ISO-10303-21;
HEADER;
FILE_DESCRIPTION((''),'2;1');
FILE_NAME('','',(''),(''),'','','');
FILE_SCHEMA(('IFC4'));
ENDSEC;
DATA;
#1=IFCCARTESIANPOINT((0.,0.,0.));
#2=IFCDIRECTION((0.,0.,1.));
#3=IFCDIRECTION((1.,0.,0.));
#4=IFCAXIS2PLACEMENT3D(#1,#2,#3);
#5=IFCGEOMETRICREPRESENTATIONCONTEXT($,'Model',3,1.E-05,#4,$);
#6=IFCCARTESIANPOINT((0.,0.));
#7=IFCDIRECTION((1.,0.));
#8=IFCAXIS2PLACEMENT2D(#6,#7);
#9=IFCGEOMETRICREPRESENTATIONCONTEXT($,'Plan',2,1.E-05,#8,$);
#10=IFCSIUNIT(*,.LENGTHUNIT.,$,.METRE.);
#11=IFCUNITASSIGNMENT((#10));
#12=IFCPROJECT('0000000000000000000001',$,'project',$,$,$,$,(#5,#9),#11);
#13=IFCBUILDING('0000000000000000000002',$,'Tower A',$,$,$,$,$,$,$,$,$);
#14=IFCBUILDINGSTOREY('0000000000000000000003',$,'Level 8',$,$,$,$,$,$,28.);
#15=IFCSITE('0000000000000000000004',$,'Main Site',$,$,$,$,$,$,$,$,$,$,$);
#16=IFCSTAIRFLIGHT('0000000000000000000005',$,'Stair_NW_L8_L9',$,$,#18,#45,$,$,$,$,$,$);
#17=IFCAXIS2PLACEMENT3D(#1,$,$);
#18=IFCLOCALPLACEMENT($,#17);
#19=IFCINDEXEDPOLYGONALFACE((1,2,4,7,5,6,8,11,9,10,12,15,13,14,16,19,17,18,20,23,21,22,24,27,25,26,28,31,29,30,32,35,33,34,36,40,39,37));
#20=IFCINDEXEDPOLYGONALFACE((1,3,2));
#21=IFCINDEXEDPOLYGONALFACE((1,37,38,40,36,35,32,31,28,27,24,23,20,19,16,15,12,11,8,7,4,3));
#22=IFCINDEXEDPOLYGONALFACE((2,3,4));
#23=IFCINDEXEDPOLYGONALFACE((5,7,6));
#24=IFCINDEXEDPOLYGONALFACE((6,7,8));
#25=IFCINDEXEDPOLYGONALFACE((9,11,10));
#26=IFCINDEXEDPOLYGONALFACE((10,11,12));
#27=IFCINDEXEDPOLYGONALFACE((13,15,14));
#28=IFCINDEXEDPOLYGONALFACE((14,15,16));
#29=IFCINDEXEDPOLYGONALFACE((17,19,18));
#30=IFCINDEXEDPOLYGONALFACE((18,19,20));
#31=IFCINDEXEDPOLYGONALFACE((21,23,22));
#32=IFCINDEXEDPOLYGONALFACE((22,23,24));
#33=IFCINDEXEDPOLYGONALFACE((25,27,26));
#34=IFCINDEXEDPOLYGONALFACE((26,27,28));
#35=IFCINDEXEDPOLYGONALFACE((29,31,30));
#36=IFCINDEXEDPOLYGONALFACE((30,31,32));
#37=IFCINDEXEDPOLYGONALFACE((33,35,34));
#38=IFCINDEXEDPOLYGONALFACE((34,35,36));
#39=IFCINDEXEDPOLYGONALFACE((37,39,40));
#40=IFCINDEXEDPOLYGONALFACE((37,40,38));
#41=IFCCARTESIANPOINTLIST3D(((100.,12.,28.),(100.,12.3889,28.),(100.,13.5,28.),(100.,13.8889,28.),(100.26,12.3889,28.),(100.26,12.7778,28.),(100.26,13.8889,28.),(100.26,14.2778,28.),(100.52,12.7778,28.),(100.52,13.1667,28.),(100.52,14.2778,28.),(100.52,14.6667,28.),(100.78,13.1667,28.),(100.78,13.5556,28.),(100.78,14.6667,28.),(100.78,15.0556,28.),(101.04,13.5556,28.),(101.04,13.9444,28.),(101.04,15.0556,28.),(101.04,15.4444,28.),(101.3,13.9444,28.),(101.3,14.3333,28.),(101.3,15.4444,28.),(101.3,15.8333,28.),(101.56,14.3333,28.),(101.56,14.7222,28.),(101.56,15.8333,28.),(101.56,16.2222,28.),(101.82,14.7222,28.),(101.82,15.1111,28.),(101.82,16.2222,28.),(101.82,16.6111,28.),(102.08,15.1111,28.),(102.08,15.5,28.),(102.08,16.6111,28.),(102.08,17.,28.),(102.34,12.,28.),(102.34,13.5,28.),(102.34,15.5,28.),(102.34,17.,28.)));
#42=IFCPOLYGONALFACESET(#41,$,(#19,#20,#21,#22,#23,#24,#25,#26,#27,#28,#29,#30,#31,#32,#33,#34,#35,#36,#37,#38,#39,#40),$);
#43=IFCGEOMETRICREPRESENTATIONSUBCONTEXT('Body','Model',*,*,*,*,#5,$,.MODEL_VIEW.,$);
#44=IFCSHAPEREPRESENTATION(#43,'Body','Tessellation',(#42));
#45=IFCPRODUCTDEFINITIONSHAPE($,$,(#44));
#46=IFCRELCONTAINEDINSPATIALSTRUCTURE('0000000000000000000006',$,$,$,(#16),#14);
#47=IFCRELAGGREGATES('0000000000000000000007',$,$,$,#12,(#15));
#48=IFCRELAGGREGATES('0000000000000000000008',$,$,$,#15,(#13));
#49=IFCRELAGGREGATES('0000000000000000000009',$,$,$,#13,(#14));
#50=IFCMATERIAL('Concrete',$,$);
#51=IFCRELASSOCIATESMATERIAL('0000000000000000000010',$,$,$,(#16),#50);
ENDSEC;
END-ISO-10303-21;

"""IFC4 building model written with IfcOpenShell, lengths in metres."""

from ifc_helpers import new_model, si_unit, frame, origin_with_axes, origin_2d_with_axis, place, context, subcontext, project, spatial, line, indexed_curve, outline, extrude, material, element, save


model = new_model("IFC4")

# Units and contexts
model_context = context("Model", 3, precision=1e-05, world=origin_with_axes())
plan_context = context("Plan", 2, precision=1e-05, world=origin_2d_with_axis())
body_context = subcontext(model_context, "Body", "Model", "MODEL_VIEW")
ifc_project = project(units=[si_unit("LENGTHUNIT", "METRE")], contexts=[model_context, plan_context])

# Site, building, storey
site = spatial("IfcSite", under=ifc_project, Name="Main Site")
building = spatial("IfcBuilding", under=site, Name="Tower A")
storey = spatial("IfcBuildingStorey", under=building, Name="Level 8", Elevation=28.0)

# Stair flight
ifc_material_1 = material(Name="Concrete")
stair_flight_placement = place(None, frame((100.0, 12.0, 28.0), z_axis=(0.0, 0.0, 1.0), x_axis=(1.0, 0.0, 0.0)))
element("IfcStairFlight", 1, at=stair_flight_placement, inside=storey, material=ifc_material_1, Name="Stair_NW_L8_L9", context=body_context, shape_type="SweptSolid", body=[
    extrude(outline(indexed_curve([(0.0, 0.0), (0.0, 0.3889), (0.26, 0.3889), (0.26, 0.7778), (0.52, 0.7778), (0.52, 1.1667), (0.78, 1.1667), (0.78, 1.5556), (1.04, 1.5556), (1.04, 1.9444), (1.3, 1.9444), (1.3, 2.3333), (1.56, 2.3333), (1.56, 2.7222), (1.82, 2.7222), (1.82, 3.1111), (2.08, 3.1111), (2.08, 3.5), (2.34, 3.5), (2.34, 0.0)], segments=[line(1, 2, 3, 4, 5, 6, 7, 8, 9, 10, 11, 12, 13, 14, 15, 16, 17, 18, 19, 20, 1)])), origin_with_axes(), (0.0, 1.0, 0.0), 1.5),
])

save(model, "model.ifc")
